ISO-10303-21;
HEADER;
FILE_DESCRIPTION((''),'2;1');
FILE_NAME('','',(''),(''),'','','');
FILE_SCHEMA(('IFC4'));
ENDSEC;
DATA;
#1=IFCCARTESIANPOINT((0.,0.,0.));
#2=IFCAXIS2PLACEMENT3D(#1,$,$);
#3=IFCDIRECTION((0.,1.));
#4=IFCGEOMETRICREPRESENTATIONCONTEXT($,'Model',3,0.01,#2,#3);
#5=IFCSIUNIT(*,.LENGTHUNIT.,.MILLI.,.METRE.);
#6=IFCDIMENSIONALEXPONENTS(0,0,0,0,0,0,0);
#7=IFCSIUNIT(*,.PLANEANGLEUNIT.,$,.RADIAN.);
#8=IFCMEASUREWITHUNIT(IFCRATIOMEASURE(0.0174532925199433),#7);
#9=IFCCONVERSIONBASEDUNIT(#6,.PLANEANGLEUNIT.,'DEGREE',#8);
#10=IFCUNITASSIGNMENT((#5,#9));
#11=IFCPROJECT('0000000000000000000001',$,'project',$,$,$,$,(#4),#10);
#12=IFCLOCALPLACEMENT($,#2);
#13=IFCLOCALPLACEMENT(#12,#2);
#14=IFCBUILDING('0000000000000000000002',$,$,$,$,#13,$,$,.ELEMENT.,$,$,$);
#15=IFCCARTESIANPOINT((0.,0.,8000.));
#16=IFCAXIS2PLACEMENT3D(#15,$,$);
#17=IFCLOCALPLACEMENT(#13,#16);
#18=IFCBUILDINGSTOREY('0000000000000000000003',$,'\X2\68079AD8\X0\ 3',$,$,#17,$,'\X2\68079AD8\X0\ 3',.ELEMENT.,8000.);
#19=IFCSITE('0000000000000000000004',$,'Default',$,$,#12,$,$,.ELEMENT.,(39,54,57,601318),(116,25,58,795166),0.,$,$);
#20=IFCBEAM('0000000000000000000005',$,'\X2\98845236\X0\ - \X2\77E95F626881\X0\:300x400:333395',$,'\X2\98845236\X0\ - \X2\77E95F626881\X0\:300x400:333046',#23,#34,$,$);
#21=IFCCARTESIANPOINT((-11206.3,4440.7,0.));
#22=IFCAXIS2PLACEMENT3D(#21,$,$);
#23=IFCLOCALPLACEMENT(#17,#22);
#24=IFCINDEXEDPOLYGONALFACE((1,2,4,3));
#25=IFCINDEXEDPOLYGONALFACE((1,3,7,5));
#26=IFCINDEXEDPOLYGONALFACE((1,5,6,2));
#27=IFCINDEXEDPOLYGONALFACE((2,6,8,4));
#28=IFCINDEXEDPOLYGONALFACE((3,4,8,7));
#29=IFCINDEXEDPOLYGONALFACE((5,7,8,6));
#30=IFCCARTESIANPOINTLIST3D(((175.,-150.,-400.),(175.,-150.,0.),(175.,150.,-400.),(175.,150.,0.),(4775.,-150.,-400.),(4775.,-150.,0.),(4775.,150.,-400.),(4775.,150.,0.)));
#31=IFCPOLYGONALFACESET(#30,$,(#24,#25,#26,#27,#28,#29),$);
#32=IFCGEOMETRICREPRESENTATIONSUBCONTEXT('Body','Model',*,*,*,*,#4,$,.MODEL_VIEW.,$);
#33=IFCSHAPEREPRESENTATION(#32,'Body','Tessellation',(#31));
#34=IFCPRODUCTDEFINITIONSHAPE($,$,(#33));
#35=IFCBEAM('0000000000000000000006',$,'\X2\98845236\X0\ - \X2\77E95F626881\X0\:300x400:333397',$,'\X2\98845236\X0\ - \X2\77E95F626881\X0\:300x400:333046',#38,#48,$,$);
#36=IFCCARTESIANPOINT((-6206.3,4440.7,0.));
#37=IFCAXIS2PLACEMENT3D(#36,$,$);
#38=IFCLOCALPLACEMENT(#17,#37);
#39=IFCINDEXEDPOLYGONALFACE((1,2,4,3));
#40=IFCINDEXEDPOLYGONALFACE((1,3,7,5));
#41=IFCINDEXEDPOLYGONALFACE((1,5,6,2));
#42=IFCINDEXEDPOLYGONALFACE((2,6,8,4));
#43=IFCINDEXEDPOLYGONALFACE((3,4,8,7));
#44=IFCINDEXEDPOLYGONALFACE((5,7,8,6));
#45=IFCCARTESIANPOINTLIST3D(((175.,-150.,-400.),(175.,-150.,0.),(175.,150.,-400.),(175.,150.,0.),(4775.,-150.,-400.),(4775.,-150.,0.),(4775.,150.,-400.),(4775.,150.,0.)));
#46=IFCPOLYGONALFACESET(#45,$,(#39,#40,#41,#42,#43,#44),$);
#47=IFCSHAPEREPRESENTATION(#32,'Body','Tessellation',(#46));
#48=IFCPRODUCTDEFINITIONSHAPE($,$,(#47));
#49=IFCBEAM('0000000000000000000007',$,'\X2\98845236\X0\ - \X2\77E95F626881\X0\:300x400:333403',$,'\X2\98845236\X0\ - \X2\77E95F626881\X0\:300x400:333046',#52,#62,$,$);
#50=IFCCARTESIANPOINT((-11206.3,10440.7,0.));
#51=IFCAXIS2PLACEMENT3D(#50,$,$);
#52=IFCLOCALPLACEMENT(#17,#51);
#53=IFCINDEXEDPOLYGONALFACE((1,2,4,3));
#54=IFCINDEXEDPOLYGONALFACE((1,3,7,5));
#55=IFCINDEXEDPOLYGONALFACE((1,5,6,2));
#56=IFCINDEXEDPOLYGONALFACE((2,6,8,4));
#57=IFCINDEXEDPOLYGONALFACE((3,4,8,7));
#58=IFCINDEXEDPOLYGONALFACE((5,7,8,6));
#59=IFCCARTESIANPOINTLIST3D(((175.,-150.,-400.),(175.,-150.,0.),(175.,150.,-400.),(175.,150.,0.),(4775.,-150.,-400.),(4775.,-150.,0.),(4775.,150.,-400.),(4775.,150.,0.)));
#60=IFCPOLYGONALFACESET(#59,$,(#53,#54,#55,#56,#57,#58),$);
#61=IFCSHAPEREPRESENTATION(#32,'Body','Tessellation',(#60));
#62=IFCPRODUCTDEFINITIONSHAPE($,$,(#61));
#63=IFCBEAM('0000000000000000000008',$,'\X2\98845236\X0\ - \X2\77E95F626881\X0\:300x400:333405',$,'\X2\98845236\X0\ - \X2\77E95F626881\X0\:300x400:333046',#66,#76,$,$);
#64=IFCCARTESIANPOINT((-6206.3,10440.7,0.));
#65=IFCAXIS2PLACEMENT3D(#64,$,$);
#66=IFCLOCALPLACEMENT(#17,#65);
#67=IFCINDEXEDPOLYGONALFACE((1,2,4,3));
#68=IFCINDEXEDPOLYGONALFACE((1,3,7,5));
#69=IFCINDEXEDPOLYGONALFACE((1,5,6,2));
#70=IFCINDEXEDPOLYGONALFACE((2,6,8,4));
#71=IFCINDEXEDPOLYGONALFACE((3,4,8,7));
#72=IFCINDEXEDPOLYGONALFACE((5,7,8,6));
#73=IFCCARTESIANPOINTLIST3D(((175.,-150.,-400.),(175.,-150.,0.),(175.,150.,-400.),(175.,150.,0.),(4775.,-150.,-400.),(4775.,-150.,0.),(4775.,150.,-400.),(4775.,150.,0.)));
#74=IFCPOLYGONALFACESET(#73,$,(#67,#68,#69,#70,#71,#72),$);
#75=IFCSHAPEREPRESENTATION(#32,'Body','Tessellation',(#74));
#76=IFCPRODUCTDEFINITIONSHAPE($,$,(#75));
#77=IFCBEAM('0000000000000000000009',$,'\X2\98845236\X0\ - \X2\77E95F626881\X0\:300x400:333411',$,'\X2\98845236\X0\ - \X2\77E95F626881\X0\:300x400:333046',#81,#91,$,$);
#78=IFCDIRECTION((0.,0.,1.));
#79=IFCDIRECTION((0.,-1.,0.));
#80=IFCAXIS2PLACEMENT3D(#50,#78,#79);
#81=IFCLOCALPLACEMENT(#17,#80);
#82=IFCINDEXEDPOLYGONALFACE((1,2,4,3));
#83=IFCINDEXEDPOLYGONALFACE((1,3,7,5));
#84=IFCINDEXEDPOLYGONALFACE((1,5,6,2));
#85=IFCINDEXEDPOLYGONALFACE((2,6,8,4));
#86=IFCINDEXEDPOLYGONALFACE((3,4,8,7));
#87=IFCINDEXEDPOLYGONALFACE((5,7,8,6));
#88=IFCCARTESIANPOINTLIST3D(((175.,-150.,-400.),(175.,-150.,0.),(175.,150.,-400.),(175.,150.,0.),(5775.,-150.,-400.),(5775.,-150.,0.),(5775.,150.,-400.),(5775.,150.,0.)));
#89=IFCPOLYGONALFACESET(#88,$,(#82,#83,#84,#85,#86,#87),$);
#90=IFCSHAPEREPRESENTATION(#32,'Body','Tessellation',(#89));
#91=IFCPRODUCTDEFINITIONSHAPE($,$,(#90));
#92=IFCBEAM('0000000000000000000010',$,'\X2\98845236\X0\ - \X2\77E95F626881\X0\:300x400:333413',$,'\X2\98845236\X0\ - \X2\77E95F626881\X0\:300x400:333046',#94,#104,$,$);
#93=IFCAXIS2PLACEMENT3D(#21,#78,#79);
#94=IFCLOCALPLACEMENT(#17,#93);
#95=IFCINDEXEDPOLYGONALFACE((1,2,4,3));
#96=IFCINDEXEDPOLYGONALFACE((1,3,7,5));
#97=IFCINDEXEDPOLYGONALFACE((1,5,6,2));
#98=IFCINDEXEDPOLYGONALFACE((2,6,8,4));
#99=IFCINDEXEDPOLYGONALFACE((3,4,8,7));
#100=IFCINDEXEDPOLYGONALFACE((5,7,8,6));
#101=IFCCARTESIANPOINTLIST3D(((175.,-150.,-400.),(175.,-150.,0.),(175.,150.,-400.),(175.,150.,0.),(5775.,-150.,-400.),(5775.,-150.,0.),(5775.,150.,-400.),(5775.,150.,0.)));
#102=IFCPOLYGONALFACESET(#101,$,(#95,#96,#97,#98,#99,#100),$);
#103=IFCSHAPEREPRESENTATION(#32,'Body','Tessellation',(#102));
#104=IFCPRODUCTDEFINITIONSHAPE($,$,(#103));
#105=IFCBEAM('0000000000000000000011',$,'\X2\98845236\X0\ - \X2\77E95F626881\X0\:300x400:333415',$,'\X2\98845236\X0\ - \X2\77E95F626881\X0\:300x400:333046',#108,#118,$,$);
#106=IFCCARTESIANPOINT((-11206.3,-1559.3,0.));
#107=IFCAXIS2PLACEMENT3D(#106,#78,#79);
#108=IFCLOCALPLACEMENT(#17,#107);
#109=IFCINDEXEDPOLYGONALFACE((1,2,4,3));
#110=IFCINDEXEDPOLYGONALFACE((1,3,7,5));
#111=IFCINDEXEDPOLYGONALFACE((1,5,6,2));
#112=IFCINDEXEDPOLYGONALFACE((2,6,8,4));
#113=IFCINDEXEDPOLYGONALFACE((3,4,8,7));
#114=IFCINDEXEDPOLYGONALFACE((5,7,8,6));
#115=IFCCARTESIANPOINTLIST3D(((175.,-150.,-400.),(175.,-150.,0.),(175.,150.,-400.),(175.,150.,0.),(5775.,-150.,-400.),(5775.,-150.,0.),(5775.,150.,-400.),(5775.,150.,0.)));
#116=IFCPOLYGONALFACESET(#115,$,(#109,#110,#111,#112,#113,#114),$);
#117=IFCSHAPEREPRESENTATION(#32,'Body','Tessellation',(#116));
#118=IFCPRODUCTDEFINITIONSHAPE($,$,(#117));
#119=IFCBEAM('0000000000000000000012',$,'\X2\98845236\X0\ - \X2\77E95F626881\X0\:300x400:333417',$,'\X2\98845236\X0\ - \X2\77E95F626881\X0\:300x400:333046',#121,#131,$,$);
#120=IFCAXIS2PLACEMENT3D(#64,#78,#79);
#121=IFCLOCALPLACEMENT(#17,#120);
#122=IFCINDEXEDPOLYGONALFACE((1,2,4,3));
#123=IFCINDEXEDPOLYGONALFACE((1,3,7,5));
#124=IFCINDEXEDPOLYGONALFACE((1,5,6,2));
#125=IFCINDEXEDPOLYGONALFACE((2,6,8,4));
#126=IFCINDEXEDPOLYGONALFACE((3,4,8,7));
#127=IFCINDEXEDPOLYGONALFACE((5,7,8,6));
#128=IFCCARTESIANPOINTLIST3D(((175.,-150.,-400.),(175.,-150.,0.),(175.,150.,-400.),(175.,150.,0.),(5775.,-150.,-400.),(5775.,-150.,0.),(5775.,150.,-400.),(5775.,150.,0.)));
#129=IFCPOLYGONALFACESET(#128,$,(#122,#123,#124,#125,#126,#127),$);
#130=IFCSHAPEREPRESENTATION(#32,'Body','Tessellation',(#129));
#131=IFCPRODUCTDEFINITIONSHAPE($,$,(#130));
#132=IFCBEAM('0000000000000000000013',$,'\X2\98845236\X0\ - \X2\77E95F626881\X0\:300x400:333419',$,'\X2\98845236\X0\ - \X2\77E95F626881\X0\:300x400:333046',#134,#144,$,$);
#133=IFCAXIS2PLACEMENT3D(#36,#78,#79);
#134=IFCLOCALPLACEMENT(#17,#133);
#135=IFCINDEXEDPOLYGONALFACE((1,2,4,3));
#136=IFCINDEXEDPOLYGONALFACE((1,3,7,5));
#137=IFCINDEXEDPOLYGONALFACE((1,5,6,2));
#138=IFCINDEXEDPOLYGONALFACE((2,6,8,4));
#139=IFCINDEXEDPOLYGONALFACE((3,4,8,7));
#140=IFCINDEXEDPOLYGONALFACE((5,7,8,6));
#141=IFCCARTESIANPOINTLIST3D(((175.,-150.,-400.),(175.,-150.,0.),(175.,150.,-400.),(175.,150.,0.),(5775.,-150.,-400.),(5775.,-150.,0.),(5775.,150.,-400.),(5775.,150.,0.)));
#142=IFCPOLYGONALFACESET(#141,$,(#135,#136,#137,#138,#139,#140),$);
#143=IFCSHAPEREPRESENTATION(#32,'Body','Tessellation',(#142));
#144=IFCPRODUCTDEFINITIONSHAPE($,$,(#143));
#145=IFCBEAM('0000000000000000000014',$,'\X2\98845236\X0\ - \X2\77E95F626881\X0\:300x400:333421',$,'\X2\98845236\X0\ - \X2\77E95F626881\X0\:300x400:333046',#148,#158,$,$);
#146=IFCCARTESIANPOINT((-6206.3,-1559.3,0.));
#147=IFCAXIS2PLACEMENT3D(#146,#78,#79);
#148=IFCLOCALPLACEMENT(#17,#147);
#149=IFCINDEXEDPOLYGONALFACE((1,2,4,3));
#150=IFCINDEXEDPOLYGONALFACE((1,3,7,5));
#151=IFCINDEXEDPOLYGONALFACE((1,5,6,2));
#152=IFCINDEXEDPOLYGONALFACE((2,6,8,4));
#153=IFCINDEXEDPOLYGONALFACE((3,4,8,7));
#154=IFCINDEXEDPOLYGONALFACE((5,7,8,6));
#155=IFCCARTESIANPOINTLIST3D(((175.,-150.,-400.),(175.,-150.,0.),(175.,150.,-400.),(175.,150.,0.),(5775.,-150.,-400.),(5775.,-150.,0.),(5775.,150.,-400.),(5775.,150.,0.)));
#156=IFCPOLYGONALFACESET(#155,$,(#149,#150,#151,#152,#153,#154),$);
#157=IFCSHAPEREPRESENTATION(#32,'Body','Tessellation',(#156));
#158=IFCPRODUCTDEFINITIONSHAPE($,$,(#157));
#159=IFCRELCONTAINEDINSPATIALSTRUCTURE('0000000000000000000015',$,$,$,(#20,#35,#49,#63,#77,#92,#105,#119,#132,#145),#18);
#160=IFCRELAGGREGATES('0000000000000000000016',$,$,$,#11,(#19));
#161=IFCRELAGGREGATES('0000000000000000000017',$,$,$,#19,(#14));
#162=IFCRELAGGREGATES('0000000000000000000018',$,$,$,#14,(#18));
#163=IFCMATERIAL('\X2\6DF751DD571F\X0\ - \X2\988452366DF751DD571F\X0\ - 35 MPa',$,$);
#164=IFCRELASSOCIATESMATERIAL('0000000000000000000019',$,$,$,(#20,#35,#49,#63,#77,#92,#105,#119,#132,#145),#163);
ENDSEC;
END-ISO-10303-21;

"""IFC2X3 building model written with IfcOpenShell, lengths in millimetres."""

from ifc_helpers import new_model, entity, si_unit, converted_unit, direction, frame, frame_2d, origin, origin_2d_with_axis, place, context, subcontext, project, spatial, rectangle, extrude, material, element, save


model = new_model("IFC2X3")

# Units and contexts
model_context = context("Model", 3, precision=0.01, world=origin(), true_north=direction((0.0, 1.0)))
body_context = subcontext(model_context, "Body", "Model", "MODEL_VIEW")
ifc_project = project(units=[si_unit("LENGTHUNIT", "METRE", prefix="MILLI"), converted_unit("PLANEANGLEUNIT", "DEGREE", entity("IfcRatioMeasure", 0.0174532925199433), si_unit("PLANEANGLEUNIT", "RADIAN"), dimensions=[0, 0, 0, 0, 0, 0, 0])], contexts=[model_context])

# Site, building, storey
site_placement = place(None, origin())
site = spatial("IfcSite", under=ifc_project, at=site_placement, Name="Default", CompositionType="ELEMENT", RefLatitude=(39, 54, 57, 601318), RefLongitude=(116, 25, 58, 795166), RefElevation=0.0)
building_placement = place(site_placement, origin())
building = spatial("IfcBuilding", under=site, at=building_placement, CompositionType="ELEMENT")
storey_placement = place(building_placement, frame((0.0, 0.0, 8000.0)))
storey = spatial("IfcBuildingStorey", under=building, at=storey_placement, Name="标高 3", LongName="标高 3", CompositionType="ELEMENT", Elevation=8000.0)

# Shared definitions
ifc_material = material(Name="混凝土 - 预制混凝土 - 35 MPa")

# Beams
beam_1_placement = place(storey_placement, frame((-11206.3, 4440.7, 0.0)))
element("IfcBeam", 1, at=beam_1_placement, inside=storey, material=ifc_material, Name="预制 - 矩形梁:300x400:333395", ObjectType="预制 - 矩形梁:300x400:333046", context=body_context, shape_type="SweptSolid", body=[
    extrude(rectangle(XDim=400.0, YDim=300.0, at=frame_2d((0.0, 0.0), x_axis=(1.0, 0.0))), frame((175.0, 0.0, -200.0), z_axis=(1.0, 0.0, 0.0), x_axis=(0.0, 0.0, -1.0)), (0.0, 0.0, 1.0), 4600.0),
])
beam_2_placement = place(storey_placement, frame((-6206.3, 4440.7, 0.0)))
element("IfcBeam", 2, at=beam_2_placement, inside=storey, material=ifc_material, Name="预制 - 矩形梁:300x400:333397", ObjectType="预制 - 矩形梁:300x400:333046", context=body_context, shape_type="SweptSolid", body=[
    extrude(rectangle(XDim=400.0, YDim=300.0, at=frame_2d((0.0, 0.0), x_axis=(1.0, 0.0))), frame((175.0, 0.0, -200.0), z_axis=(1.0, 0.0, 0.0), x_axis=(0.0, 0.0, -1.0)), (0.0, 0.0, 1.0), 4600.0),
])
beam_3_placement = place(storey_placement, frame((-11206.3, 10440.7, 0.0)))
element("IfcBeam", 3, at=beam_3_placement, inside=storey, material=ifc_material, Name="预制 - 矩形梁:300x400:333403", ObjectType="预制 - 矩形梁:300x400:333046", context=body_context, shape_type="SweptSolid", body=[
    extrude(rectangle(XDim=400.0, YDim=300.0, at=frame_2d((0.0, 0.0), x_axis=(1.0, 0.0))), frame((175.0, 0.0, -200.0), z_axis=(1.0, 0.0, 0.0), x_axis=(0.0, 0.0, -1.0)), (0.0, 0.0, 1.0), 4600.0),
])
beam_4_placement = place(storey_placement, frame((-6206.3, 10440.7, 0.0)))
element("IfcBeam", 4, at=beam_4_placement, inside=storey, material=ifc_material, Name="预制 - 矩形梁:300x400:333405", ObjectType="预制 - 矩形梁:300x400:333046", context=body_context, shape_type="SweptSolid", body=[
    extrude(rectangle(XDim=400.0, YDim=300.0, at=frame_2d((0.0, 0.0), x_axis=(1.0, 0.0))), frame((175.0, 0.0, -200.0), z_axis=(1.0, 0.0, 0.0), x_axis=(0.0, 0.0, -1.0)), (0.0, 0.0, 1.0), 4600.0),
])
for number, where, z_axis, x_axis, name in (
    (5, (-11206.3, 10440.7, 0.0), (0.0, 0.0, 1.0), (0.0, -1.0, 0.0), "预制 - 矩形梁:300x400:333411"),
    (6, (-11206.3, 4440.7, 0.0), (0.0, 0.0, 1.0), (0.0, -1.0, 0.0), "预制 - 矩形梁:300x400:333413"),
):
    element("IfcBeam", number, at=place(storey_placement, frame(where, z_axis=z_axis, x_axis=x_axis)), inside=storey, material=ifc_material, Name=name, ObjectType="预制 - 矩形梁:300x400:333046", context=body_context, shape_type="SweptSolid", body=[
        extrude(rectangle(XDim=400.0, YDim=300.0, at=origin_2d_with_axis()), frame((175.0, 0.0, -200.0), z_axis=(1.0, 0.0, 0.0), x_axis=(0.0, 0.0, -1.0)), (0.0, 0.0, 1.0), 5600.0),
    ])
beam_5_placement = place(storey_placement, frame((-11206.3, -1559.3, 0.0), z_axis=(0.0, 0.0, 1.0), x_axis=(0.0, -1.0, 0.0)))
element("IfcBeam", 7, at=beam_5_placement, inside=storey, material=ifc_material, Name="预制 - 矩形梁:300x400:333415", ObjectType="预制 - 矩形梁:300x400:333046", context=body_context, shape_type="SweptSolid", body=[
    extrude(rectangle(XDim=400.0, YDim=300.0, at=frame_2d((0.0, 0.0), x_axis=(1.0, 0.0))), frame((175.0, 0.0, -200.0), z_axis=(1.0, 0.0, 0.0), x_axis=(0.0, 0.0, -1.0)), (0.0, 0.0, 1.0), 5600.0),
])
for number, where, z_axis, x_axis, name in (
    (8, (-6206.3, 10440.7, 0.0), (0.0, 0.0, 1.0), (0.0, -1.0, 0.0), "预制 - 矩形梁:300x400:333417"),
    (9, (-6206.3, 4440.7, 0.0), (0.0, 0.0, 1.0), (0.0, -1.0, 0.0), "预制 - 矩形梁:300x400:333419"),
    (10, (-6206.3, -1559.3, 0.0), (0.0, 0.0, 1.0), (0.0, -1.0, 0.0), "预制 - 矩形梁:300x400:333421"),
):
    element("IfcBeam", number, at=place(storey_placement, frame(where, z_axis=z_axis, x_axis=x_axis)), inside=storey, material=ifc_material, Name=name, ObjectType="预制 - 矩形梁:300x400:333046", context=body_context, shape_type="SweptSolid", body=[
        extrude(rectangle(XDim=400.0, YDim=300.0, at=origin_2d_with_axis()), frame((175.0, 0.0, -200.0), z_axis=(1.0, 0.0, 0.0), x_axis=(0.0, 0.0, -1.0)), (0.0, 0.0, 1.0), 5600.0),
    ])

save(model, "model.ifc")
